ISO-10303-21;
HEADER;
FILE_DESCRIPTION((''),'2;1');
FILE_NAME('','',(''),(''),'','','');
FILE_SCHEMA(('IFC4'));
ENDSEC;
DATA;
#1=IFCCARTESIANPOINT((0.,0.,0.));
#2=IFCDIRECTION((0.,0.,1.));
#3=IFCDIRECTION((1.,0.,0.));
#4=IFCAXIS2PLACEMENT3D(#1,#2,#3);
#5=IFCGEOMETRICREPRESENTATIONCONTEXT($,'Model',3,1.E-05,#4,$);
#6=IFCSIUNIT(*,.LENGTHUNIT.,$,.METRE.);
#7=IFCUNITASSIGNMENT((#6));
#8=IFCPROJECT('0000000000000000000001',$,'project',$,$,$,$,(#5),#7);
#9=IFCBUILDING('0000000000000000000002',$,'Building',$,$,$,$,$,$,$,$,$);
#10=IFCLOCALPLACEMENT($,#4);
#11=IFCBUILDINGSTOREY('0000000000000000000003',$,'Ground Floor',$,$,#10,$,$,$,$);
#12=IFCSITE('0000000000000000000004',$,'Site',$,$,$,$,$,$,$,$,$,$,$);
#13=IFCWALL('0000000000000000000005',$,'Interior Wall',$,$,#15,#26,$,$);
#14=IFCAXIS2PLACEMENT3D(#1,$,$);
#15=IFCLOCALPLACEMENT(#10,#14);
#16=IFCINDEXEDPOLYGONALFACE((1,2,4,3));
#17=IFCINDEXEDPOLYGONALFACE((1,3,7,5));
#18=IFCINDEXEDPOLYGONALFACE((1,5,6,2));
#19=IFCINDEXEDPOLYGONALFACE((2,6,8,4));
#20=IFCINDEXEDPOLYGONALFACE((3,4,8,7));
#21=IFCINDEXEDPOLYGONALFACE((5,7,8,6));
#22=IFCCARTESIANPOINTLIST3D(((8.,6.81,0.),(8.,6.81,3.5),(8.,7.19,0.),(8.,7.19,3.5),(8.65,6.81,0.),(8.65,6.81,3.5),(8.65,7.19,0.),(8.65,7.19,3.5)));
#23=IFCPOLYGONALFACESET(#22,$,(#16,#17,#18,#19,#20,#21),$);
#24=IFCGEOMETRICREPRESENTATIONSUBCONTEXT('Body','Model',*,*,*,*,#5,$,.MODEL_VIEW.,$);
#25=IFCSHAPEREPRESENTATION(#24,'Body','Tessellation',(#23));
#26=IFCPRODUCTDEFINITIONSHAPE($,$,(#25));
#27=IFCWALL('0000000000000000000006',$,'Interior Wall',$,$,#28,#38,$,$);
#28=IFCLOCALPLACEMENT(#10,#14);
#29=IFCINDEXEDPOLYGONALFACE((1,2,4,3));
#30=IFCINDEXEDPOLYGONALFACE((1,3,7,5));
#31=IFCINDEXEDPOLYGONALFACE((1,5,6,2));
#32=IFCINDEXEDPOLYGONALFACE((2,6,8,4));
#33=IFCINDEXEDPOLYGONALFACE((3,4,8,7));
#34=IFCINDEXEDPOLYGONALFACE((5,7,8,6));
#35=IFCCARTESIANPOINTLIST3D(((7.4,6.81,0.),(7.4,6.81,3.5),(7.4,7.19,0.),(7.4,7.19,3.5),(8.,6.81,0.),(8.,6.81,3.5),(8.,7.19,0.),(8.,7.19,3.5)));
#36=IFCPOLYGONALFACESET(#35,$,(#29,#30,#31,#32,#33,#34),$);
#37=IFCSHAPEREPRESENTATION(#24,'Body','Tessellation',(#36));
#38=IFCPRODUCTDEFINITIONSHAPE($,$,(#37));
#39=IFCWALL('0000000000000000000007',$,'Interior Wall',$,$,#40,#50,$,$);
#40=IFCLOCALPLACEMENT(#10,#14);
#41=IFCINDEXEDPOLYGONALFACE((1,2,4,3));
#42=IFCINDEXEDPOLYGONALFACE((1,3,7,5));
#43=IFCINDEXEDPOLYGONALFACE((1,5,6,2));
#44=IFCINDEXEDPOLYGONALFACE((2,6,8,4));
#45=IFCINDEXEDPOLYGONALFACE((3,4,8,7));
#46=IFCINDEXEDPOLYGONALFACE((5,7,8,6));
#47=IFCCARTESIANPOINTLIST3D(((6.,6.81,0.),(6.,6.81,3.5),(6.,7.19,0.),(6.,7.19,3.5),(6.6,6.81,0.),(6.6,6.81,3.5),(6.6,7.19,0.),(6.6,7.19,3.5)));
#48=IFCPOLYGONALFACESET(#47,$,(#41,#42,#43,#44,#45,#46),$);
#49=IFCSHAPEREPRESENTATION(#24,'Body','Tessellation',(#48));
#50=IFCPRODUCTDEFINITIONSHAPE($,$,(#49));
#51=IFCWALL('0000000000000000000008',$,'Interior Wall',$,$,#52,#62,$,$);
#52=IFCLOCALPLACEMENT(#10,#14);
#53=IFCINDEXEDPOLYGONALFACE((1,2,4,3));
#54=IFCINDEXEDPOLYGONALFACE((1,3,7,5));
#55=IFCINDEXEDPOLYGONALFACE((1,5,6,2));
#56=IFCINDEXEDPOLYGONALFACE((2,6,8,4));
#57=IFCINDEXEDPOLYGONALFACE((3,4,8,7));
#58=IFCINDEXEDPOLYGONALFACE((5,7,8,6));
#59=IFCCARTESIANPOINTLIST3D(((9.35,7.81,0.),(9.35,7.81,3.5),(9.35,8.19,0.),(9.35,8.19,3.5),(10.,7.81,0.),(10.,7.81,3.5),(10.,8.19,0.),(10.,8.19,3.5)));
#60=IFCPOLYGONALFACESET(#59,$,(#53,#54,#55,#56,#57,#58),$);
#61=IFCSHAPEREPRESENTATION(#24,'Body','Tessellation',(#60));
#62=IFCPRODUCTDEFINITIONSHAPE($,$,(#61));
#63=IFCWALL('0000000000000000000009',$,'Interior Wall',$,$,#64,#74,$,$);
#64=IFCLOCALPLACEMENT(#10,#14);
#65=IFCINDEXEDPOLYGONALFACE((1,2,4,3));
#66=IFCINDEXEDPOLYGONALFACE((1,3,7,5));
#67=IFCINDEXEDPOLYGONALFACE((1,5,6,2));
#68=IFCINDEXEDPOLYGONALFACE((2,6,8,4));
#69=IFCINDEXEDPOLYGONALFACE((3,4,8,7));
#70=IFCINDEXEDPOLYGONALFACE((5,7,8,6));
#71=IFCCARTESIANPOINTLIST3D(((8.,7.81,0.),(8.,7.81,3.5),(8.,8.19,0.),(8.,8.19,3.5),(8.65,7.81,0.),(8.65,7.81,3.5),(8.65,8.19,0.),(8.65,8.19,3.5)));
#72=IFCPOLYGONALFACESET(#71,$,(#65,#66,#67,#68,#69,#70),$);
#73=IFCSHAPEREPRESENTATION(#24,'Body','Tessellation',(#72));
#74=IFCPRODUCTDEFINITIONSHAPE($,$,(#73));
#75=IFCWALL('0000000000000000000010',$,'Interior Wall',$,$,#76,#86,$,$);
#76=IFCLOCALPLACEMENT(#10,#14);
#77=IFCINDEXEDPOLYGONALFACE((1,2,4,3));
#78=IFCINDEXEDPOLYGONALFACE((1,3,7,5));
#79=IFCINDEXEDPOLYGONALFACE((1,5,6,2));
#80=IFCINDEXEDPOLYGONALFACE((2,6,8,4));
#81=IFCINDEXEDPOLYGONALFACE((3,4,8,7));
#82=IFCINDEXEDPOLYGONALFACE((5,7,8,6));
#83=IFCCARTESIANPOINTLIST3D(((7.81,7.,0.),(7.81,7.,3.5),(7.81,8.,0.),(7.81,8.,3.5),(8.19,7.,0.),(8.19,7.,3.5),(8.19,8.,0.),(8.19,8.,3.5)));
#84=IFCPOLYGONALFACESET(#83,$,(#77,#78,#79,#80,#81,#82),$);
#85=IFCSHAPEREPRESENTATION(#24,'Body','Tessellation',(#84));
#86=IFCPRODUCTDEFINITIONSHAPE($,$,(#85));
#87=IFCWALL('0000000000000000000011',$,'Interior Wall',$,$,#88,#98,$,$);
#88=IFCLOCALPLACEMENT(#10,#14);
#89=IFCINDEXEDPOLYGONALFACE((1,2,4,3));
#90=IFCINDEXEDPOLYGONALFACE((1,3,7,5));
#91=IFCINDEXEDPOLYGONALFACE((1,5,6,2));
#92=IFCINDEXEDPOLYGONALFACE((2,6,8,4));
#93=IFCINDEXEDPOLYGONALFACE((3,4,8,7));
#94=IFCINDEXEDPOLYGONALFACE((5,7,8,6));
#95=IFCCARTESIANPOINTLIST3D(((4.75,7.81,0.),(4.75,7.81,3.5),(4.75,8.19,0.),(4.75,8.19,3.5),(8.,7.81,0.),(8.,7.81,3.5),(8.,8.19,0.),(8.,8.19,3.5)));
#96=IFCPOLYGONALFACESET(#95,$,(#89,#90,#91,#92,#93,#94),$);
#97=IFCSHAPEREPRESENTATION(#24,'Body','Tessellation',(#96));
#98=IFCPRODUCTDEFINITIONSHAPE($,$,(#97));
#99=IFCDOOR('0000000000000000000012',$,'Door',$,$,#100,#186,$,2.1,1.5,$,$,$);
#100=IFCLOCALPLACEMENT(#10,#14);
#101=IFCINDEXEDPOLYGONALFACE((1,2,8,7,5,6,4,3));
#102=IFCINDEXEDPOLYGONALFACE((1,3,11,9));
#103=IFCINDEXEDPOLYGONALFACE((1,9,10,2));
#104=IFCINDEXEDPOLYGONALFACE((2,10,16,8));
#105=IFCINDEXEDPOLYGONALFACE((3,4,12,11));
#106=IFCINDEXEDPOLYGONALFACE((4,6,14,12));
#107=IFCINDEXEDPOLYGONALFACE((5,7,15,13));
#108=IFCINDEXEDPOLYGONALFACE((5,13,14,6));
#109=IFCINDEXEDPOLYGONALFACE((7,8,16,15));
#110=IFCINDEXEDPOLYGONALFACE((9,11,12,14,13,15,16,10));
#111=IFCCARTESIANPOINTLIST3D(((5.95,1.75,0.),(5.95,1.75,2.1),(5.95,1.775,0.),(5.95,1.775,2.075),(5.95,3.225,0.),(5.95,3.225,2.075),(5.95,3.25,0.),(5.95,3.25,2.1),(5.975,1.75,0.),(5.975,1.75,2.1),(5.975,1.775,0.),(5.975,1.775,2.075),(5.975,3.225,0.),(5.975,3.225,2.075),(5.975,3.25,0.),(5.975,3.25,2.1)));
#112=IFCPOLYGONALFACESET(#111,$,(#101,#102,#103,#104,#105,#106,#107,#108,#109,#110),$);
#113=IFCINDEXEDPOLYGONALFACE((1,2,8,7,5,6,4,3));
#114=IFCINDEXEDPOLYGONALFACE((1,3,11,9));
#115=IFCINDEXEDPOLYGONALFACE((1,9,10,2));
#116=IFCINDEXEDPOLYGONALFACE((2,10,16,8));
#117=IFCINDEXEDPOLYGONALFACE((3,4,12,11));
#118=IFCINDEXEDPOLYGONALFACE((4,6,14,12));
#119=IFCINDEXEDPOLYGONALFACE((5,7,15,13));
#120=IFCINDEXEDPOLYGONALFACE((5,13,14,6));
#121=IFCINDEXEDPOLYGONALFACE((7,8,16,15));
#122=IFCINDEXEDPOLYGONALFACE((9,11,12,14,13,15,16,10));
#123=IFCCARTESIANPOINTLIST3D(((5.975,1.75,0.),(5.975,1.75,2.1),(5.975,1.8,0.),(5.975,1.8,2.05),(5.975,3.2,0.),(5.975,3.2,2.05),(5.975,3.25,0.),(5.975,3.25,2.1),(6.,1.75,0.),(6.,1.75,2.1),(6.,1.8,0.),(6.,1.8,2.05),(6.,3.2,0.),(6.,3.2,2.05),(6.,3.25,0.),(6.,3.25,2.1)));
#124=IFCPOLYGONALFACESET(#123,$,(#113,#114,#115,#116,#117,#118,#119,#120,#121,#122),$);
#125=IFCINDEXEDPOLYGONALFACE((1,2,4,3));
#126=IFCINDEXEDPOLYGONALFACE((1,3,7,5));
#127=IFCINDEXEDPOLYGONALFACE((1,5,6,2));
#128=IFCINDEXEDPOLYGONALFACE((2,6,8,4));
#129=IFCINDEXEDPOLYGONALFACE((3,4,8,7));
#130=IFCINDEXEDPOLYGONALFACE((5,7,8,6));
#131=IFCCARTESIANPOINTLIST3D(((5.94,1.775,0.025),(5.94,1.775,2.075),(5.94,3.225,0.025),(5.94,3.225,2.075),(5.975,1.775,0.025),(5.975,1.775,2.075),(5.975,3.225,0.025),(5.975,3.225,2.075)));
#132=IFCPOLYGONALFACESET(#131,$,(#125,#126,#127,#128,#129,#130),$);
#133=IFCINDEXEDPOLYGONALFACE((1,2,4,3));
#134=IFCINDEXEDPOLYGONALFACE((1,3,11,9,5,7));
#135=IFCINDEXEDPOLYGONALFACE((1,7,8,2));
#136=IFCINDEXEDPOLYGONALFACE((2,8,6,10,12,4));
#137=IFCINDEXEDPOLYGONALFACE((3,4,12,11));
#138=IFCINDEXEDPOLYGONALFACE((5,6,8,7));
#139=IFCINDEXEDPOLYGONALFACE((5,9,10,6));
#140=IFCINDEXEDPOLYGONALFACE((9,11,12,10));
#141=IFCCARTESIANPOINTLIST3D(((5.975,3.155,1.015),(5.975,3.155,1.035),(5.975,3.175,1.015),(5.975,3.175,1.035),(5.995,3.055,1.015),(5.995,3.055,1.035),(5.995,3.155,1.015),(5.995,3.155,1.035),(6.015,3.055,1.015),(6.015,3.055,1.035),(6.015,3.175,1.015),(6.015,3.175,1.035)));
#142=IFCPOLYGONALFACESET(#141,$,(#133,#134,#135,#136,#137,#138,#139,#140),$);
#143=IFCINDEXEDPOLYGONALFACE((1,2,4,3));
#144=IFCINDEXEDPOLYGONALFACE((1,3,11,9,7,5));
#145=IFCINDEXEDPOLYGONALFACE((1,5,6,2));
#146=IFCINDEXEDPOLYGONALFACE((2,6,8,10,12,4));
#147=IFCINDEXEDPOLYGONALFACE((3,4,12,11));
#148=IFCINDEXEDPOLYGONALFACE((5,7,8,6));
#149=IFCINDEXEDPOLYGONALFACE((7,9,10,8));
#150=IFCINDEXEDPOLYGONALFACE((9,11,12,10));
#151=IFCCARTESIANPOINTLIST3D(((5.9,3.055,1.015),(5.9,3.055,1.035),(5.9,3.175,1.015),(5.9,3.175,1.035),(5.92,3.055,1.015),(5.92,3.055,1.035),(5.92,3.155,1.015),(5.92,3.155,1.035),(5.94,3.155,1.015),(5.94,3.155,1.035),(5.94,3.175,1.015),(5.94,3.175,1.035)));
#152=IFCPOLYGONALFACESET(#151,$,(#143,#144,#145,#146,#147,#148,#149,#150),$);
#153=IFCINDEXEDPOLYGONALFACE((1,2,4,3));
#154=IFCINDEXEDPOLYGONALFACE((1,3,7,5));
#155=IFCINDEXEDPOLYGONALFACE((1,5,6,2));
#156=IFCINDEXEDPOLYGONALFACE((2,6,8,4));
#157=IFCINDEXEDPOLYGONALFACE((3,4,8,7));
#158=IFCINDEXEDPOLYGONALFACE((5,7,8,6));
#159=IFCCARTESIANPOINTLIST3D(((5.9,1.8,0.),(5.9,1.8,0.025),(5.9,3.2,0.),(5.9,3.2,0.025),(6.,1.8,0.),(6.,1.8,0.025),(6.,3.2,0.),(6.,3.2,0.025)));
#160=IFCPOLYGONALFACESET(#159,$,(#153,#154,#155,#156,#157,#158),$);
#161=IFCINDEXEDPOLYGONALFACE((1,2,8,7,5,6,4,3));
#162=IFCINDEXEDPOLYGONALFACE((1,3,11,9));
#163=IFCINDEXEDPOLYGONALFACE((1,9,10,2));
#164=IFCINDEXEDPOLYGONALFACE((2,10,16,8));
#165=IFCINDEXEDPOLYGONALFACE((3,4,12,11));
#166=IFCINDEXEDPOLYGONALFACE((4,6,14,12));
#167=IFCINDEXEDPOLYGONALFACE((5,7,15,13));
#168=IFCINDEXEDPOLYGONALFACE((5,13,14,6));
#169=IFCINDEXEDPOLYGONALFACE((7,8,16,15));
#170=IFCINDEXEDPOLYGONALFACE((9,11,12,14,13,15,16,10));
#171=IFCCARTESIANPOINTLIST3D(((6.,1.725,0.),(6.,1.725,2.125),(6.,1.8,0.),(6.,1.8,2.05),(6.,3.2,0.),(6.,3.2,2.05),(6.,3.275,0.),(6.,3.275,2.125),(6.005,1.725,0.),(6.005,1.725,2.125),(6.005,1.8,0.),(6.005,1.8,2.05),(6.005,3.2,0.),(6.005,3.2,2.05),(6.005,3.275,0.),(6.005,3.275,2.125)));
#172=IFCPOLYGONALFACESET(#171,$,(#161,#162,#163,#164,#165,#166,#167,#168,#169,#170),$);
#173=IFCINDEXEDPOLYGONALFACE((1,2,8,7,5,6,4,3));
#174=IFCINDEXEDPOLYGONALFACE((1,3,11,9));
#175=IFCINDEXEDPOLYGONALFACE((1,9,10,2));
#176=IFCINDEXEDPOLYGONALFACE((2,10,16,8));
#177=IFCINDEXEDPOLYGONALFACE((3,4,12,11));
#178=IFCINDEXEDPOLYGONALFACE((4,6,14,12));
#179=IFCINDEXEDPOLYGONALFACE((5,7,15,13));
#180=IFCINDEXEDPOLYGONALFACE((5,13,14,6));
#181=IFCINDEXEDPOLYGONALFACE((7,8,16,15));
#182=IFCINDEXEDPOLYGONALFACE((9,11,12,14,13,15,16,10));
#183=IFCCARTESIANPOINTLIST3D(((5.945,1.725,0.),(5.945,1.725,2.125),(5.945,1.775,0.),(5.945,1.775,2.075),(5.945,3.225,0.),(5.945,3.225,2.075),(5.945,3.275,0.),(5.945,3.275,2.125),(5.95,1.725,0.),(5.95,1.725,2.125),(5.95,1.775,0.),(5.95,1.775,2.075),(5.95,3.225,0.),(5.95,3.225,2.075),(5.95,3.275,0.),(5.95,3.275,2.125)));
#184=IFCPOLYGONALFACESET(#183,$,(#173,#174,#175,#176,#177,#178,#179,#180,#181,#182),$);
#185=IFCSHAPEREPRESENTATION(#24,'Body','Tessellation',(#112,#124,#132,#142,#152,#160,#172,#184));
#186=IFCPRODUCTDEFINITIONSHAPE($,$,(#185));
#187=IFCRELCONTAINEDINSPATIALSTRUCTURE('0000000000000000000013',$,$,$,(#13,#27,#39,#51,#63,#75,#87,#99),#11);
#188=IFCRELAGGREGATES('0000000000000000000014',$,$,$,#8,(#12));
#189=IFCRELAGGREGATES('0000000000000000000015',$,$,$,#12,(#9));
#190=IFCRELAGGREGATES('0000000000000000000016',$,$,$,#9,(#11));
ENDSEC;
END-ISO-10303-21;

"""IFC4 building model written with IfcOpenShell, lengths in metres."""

from ifc_helpers import new_model, si_unit, frame, origin_with_axes, place, context, subcontext, project, spatial, line, indexed_curve, outline, extrude, element, save


model = new_model("IFC4")

# Units and contexts
model_context = context("Model", 3, precision=1e-05, world=origin_with_axes())
body_context = subcontext(model_context, "Body", "Model", "MODEL_VIEW")
ifc_project = project(units=[si_unit("LENGTHUNIT", "METRE")], contexts=[model_context])

# Site, building, storey
site = spatial("IfcSite", under=ifc_project, Name="Site")
building = spatial("IfcBuilding", under=site, Name="Building")
storey_placement = place(None, origin_with_axes())
storey = spatial("IfcBuildingStorey", under=building, at=storey_placement, Name="Ground Floor")

# Walls
for number, where, z_axis, x_axis, name in (
    (1, (8.65, 7.0, 0.0), (0.0, 0.0, 1.0), (-1.0, 0.0, 0.0), "Interior Wall"),
):
    element("IfcWall", number, at=place(storey_placement, frame(where, z_axis=z_axis, x_axis=x_axis)), inside=storey, Name=name, context=body_context, shape_type="SweptSolid", body=[
        extrude(outline(indexed_curve([(0.0, 0.0), (0.0, 0.38), (0.65, 0.38), (0.65, 0.0), (0.0, 0.0)], self_intersect=False)), frame((0.0, -0.19, 0.0), z_axis=(0.0, 0.0, 1.0), x_axis=(1.0, 0.0, 0.0)), (0.0, 0.0, 1.0), 3.5),
    ])
for number, where, z_axis, x_axis, name in (
    (2, (8.0, 7.0, 0.0), (0.0, 0.0, 1.0), (-1.0, 0.0, 0.0), "Interior Wall"),
    (3, (6.6, 7.0, 0.0), (0.0, 0.0, 1.0), (-1.0, 0.0, 0.0), "Interior Wall"),
):
    element("IfcWall", number, at=place(storey_placement, frame(where, z_axis=z_axis, x_axis=x_axis)), inside=storey, Name=name, context=body_context, shape_type="SweptSolid", body=[
        extrude(outline(indexed_curve([(0.0, 0.0), (0.0, 0.38), (0.6, 0.38), (0.6, 0.0), (0.0, 0.0)], self_intersect=False)), frame((0.0, -0.19, 0.0), z_axis=(0.0, 0.0, 1.0), x_axis=(1.0, 0.0, 0.0)), (0.0, 0.0, 1.0), 3.5),
    ])
for number, where, z_axis, x_axis, name in (
    (4, (10.0, 8.0, 0.0), (0.0, 0.0, 1.0), (-1.0, 0.0, 0.0), "Interior Wall"),
    (5, (8.65, 8.0, 0.0), (0.0, 0.0, 1.0), (-1.0, 0.0, 0.0), "Interior Wall"),
):
    element("IfcWall", number, at=place(storey_placement, frame(where, z_axis=z_axis, x_axis=x_axis)), inside=storey, Name=name, context=body_context, shape_type="SweptSolid", body=[
        extrude(outline(indexed_curve([(0.0, 0.0), (0.0, 0.38), (0.65, 0.38), (0.65, 0.0), (0.0, 0.0)], self_intersect=False)), frame((0.0, -0.19, 0.0), z_axis=(0.0, 0.0, 1.0), x_axis=(1.0, 0.0, 0.0)), (0.0, 0.0, 1.0), 3.5),
    ])
wall_1_placement = place(storey_placement, frame((8.0, 8.0, 0.0), z_axis=(0.0, 0.0, 1.0), x_axis=(0.0, -1.0, 0.0)))
element("IfcWall", 6, at=wall_1_placement, inside=storey, Name="Interior Wall", context=body_context, shape_type="SweptSolid", body=[
    extrude(outline(indexed_curve([(0.0, 0.0), (0.0, 0.38), (1.0, 0.38), (1.0, 0.0), (0.0, 0.0)], self_intersect=False)), frame((0.0, -0.19, 0.0), z_axis=(0.0, 0.0, 1.0), x_axis=(1.0, 0.0, 0.0)), (0.0, 0.0, 1.0), 3.5),
])
wall_2_placement = place(storey_placement, frame((8.0, 8.0, 0.0), z_axis=(0.0, 0.0, 1.0), x_axis=(-1.0, 0.0, 0.0)))
element("IfcWall", 7, at=wall_2_placement, inside=storey, Name="Interior Wall", context=body_context, shape_type="SweptSolid", body=[
    extrude(outline(indexed_curve([(0.0, 0.0), (0.0, 0.38), (3.25, 0.38), (3.25, 0.0), (0.0, 0.0)], self_intersect=False)), frame((0.0, -0.19, 0.0), z_axis=(0.0, 0.0, 1.0), x_axis=(1.0, 0.0, 0.0)), (0.0, 0.0, 1.0), 3.5),
])

# Door
door_1_placement = place(storey_placement, frame((6.0, 1.75, 0.0), z_axis=(0.0, 0.0, 1.0), x_axis=(0.0, 1.0, 0.0)))
element("IfcDoor", 8, at=door_1_placement, inside=storey, Name="Door", OverallHeight=2.1, OverallWidth=1.5, context=body_context, shape_type="SweptSolid", body=[
    extrude(outline(indexed_curve([(0.0, 0.0), (0.0, 2.1), (1.5, 2.1), (1.5, 0.0), (1.475, 0.0), (1.475, 2.075), (0.025, 2.075), (0.025, 0.0)], segments=[line(1, 2, 3, 4, 5, 6, 7, 8, 1)])), frame((0.0, 0.025, 0.0), z_axis=(0.0, -1.0, 0.0), x_axis=(1.0, 0.0, 0.0)), (0.0, 0.0, -1.0), 0.025),
    extrude(outline(indexed_curve([(0.0, 0.0), (0.0, 2.1), (1.5, 2.1), (1.5, 0.0), (1.45, 0.0), (1.45, 2.05), (0.05, 2.05), (0.05, 0.0)], segments=[line(1, 2, 3, 4, 5, 6, 7, 8, 1)])), frame((0.0, 0.0, 0.0), z_axis=(0.0, -1.0, 0.0), x_axis=(1.0, 0.0, 0.0)), (0.0, 0.0, -1.0), 0.025),
    extrude(outline(indexed_curve([(0.0, 0.0), (1.45, 0.0), (1.45, 0.035), (0.0, 0.035)], segments=[line(1, 2, 3, 4, 1)])), frame((0.025, 0.025, 0.025), z_axis=(0.0, 0.0, 1.0), x_axis=(1.0, 0.0, 0.0)), (0.0, 0.0, 1.0), 2.05),
    extrude(outline(indexed_curve([(0.0, 0.0), (0.0, -0.04), (-0.12, -0.04), (-0.12, -0.02), (-0.02, -0.02), (-0.02, 0.0)], segments=[line(1, 2, 3, 4, 5, 6, 1)])), frame((1.425, 0.025, 1.015), z_axis=(0.0, 0.0, 1.0), x_axis=(1.0, 0.0, 0.0)), (0.0, 0.0, 1.0), 0.02),
    extrude(outline(indexed_curve([(0.0, 0.0), (0.0, 0.04), (-0.12, 0.04), (-0.12, 0.02), (-0.02, 0.02), (-0.02, 0.0)], segments=[line(1, 2, 3, 4, 5, 6, 1)])), frame((1.425, 0.06, 1.015), z_axis=(0.0, 0.0, 1.0), x_axis=(1.0, 0.0, 0.0)), (0.0, 0.0, 1.0), 0.02),
    extrude(outline(indexed_curve([(0.0, 0.0), (1.4, 0.0), (1.4, 0.1), (0.0, 0.1)], segments=[line(1, 2, 3, 4, 1)])), frame((0.05, 0.0, 0.0), z_axis=(0.0, 0.0, 1.0), x_axis=(1.0, 0.0, 0.0)), (0.0, 0.0, 1.0), 0.025),
    extrude(outline(indexed_curve([(0.0, 0.0), (0.0, 2.125), (1.55, 2.125), (1.55, 0.0), (1.475, 0.0), (1.475, 2.05), (0.075, 2.05), (0.075, 0.0)], segments=[line(1, 2, 3, 4, 5, 6, 7, 8, 1)])), frame((-0.025, -0.005, 0.0), z_axis=(0.0, -1.0, 0.0), x_axis=(1.0, 0.0, 0.0)), (0.0, 0.0, -1.0), 0.005),
    extrude(outline(indexed_curve([(0.0, 0.0), (0.0, 2.125), (1.55, 2.125), (1.55, 0.0), (1.5, 0.0), (1.5, 2.075), (0.05, 2.075), (0.05, 0.0)], segments=[line(1, 2, 3, 4, 5, 6, 7, 8, 1)])), frame((-0.025, 0.05, 0.0), z_axis=(0.0, -1.0, 0.0), x_axis=(1.0, 0.0, 0.0)), (0.0, 0.0, -1.0), 0.005),
])

save(model, "model.ifc")
